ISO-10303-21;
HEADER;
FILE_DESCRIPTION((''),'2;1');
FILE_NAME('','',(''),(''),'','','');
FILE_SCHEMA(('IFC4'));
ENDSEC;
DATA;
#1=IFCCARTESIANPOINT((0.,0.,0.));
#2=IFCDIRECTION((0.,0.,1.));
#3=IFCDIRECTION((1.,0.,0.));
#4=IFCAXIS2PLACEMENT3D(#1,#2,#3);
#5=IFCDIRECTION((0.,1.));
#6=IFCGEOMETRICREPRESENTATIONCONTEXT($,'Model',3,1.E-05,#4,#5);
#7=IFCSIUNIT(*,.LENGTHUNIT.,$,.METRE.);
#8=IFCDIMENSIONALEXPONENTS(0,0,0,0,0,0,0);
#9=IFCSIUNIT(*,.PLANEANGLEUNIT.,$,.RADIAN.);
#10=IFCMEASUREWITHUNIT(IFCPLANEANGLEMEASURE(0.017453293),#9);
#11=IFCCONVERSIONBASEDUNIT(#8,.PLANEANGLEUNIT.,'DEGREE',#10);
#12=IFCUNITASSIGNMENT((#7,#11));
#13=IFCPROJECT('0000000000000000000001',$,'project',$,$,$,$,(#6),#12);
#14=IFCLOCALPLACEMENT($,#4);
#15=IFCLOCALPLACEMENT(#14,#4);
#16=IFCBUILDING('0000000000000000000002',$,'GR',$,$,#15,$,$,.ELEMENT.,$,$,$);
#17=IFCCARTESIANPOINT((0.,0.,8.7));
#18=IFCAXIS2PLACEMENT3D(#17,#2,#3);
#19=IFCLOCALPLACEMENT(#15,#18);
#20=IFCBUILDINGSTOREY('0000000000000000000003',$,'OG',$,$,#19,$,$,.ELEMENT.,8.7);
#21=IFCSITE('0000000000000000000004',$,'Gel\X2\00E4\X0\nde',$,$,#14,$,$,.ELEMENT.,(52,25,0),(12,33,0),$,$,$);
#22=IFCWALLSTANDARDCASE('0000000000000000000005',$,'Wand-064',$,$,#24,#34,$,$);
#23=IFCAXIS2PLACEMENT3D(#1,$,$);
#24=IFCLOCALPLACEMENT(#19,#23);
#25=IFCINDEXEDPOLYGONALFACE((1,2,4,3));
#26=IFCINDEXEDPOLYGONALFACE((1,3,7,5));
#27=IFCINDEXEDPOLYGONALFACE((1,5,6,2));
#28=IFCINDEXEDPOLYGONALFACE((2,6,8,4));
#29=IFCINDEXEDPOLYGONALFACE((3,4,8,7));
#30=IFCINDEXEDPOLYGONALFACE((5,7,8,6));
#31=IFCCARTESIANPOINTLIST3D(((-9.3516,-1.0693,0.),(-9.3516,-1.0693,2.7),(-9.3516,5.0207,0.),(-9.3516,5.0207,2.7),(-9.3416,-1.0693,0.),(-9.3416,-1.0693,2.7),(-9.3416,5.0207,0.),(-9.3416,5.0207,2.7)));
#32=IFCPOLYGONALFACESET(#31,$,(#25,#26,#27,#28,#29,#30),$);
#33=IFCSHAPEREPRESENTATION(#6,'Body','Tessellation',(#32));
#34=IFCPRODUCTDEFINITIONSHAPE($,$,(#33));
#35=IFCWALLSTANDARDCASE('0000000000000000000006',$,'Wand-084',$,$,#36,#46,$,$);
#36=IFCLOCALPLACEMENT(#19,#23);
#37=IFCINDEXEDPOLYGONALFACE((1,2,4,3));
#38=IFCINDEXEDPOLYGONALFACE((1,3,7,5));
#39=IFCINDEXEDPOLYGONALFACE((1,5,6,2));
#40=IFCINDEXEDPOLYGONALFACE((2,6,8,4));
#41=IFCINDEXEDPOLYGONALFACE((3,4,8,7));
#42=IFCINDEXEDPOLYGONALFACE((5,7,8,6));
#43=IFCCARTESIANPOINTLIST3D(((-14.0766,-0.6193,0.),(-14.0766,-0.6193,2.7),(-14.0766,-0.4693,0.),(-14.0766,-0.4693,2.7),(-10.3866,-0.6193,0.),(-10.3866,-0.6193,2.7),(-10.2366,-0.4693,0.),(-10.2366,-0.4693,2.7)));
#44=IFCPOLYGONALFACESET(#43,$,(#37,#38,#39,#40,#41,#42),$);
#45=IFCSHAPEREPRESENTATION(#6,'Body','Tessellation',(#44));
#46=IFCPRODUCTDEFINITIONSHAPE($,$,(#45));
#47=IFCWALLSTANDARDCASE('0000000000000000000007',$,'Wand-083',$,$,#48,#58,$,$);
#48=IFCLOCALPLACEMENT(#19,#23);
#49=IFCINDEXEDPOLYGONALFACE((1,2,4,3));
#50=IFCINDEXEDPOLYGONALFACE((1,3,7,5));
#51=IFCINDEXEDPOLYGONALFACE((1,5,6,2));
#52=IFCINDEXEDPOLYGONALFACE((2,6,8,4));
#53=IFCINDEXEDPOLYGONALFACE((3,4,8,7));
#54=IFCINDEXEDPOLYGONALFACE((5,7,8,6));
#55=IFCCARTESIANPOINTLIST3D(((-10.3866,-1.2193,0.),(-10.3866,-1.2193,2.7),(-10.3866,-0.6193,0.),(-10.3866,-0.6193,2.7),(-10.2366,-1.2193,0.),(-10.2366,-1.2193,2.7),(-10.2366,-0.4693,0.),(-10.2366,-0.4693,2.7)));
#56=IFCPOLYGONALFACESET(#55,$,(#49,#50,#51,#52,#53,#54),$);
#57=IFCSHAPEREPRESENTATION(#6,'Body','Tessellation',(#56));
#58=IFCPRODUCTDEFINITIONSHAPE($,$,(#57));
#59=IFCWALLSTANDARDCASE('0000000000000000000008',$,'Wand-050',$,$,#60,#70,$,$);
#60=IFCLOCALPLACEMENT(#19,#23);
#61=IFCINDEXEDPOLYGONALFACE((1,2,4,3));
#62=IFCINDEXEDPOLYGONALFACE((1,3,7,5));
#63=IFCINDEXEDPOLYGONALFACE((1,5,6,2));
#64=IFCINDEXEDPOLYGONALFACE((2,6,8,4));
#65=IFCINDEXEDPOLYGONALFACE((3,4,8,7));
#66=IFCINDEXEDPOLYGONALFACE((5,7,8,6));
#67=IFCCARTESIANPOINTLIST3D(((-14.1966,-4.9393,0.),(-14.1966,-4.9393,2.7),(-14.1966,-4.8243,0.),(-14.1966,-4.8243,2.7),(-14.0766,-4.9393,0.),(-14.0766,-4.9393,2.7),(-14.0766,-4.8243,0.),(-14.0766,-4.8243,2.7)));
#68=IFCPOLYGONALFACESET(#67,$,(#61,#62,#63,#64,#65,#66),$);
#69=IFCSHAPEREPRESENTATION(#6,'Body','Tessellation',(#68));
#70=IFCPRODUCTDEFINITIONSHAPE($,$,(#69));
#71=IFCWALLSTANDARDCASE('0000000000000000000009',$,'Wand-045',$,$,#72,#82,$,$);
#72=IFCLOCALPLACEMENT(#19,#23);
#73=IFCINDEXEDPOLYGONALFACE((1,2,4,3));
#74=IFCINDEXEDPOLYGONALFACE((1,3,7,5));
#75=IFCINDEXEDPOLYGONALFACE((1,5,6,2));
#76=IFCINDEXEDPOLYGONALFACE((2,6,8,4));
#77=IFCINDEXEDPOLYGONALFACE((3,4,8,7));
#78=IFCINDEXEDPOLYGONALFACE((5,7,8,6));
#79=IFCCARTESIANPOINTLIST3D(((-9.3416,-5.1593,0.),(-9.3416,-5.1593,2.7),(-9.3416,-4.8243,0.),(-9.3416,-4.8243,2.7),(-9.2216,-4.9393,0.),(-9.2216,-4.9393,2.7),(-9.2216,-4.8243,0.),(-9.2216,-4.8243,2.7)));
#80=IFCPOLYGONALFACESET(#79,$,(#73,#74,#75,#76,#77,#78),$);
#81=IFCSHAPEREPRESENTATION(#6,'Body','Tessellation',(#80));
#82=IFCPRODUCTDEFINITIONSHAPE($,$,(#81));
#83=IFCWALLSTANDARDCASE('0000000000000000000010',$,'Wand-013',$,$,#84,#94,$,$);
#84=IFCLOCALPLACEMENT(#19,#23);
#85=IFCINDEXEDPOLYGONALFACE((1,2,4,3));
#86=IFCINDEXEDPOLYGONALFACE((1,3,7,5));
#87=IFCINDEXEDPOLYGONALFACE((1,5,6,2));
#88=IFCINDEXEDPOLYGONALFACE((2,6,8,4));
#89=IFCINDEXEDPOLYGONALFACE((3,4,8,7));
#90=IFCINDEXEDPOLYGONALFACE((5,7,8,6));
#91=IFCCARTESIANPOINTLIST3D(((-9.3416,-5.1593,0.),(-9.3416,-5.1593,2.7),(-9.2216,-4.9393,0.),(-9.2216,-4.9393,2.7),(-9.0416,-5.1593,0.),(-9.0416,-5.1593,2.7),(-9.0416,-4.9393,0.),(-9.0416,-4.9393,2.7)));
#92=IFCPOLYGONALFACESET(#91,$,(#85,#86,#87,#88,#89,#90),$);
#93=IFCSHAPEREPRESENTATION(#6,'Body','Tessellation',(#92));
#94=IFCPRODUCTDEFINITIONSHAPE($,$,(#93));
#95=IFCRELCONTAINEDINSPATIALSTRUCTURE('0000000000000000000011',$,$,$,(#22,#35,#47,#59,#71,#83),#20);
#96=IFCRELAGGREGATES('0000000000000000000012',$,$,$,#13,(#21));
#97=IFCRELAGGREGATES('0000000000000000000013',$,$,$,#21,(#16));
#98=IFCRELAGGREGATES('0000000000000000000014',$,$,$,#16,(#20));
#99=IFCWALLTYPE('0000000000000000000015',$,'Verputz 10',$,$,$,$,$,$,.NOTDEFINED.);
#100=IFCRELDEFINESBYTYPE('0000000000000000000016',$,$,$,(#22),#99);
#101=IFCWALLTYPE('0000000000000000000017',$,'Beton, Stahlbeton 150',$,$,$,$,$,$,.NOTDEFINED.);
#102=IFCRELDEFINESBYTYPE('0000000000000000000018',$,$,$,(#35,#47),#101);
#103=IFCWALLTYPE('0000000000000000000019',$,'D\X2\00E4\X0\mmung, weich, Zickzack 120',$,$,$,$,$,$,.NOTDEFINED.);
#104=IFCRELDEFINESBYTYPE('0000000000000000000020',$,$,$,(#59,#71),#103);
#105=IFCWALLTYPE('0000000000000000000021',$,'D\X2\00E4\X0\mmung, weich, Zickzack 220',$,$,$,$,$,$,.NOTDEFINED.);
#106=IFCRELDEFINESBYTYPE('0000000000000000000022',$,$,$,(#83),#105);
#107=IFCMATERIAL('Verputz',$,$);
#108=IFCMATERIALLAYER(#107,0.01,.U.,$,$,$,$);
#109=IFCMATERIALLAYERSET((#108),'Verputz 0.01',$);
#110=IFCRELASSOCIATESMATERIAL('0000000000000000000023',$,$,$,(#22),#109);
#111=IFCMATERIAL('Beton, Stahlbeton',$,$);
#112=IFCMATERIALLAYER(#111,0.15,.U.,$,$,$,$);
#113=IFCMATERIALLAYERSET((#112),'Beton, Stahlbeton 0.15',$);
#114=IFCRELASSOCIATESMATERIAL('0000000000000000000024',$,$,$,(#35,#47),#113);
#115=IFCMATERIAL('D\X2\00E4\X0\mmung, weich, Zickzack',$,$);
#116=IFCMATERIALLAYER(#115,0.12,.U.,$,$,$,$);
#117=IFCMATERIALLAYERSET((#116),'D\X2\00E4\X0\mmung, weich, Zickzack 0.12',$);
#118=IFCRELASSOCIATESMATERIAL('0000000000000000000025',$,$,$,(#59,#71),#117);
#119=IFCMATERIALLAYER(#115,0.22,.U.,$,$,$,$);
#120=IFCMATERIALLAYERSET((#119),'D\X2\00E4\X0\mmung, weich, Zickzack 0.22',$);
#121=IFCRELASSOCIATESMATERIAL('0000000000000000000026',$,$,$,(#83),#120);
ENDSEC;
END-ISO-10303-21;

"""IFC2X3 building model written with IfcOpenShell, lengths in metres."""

from ifc_helpers import new_model, entity, si_unit, converted_unit, direction, frame, origin_with_axes, place, context, project, spatial, polyline, outline, extrude, material, layer, layer_set, layer_usage, type_object, element, save


model = new_model("IFC2X3")

# Units and contexts
model_context = context("Model", 3, precision=1e-05, world=origin_with_axes(), true_north=direction((0.0, 1.0)))
ifc_project = project(units=[si_unit("LENGTHUNIT", "METRE"), converted_unit("PLANEANGLEUNIT", "DEGREE", entity("IfcPlaneAngleMeasure", 0.017453293), si_unit("PLANEANGLEUNIT", "RADIAN"), dimensions=[0, 0, 0, 0, 0, 0, 0])], contexts=[model_context])

# Site, building, storey
site_placement = place(None, origin_with_axes())
site = spatial("IfcSite", under=ifc_project, at=site_placement, Name="Gelände", CompositionType="ELEMENT", RefLatitude=(52, 25, 0), RefLongitude=(12, 33, 0))
building_placement = place(site_placement, origin_with_axes())
building = spatial("IfcBuilding", under=site, at=building_placement, Name="GR", CompositionType="ELEMENT")
storey_placement = place(building_placement, frame((0.0, 0.0, 8.7), z_axis=(0.0, 0.0, 1.0), x_axis=(1.0, 0.0, 0.0)))
storey = spatial("IfcBuildingStorey", under=building, at=storey_placement, Name="OG", CompositionType="ELEMENT", Elevation=8.7)

# Shared definitions
ifc_material_1 = material(Name="Beton, Stahlbeton")

# Wall
ifc_material_2 = material(Name="Verputz")
ifc_layer_1 = layer(ifc_material_2, 0.01, ventilated="UNKNOWN")
ifc_layer_set_1 = layer_set([ifc_layer_1], Name="Verputz 0.01")
wall_type_1 = type_object("IfcWallType", Name="Verputz 10", PredefinedType="NOTDEFINED")
ifc_layer_usage_1 = layer_usage(ifc_layer_set_1, "AXIS2", "POSITIVE", 0.0)
wall_1_placement = place(storey_placement, frame((-9.3416, -1.0693, 0.0), z_axis=(0.0, 0.0, 1.0), x_axis=(0.0, 1.0, 0.0)))
element("IfcWallStandardCase", 1, at=wall_1_placement, inside=storey, type_object=wall_type_1, material=ifc_layer_usage_1, Name="Wand-064", context=model_context, shape_type="SweptSolid", body=[
    extrude(outline(polyline([(0.0, 0.0), (6.09, 0.0), (6.09, 0.01), (0.0, 0.01), (0.0, 0.0)])), origin_with_axes(), (0.0, 0.0, 1.0), 2.7),
])

# Shared definitions
ifc_layer_2 = layer(ifc_material_1, 0.15, ventilated="UNKNOWN")
ifc_layer_set_2 = layer_set([ifc_layer_2], Name="Beton, Stahlbeton 0.15")
wall_type_2 = type_object("IfcWallType", Name="Beton, Stahlbeton 150", PredefinedType="NOTDEFINED")

# Wall
ifc_layer_usage_2 = layer_usage(ifc_layer_set_2, "AXIS2", "NEGATIVE", 0.0)
wall_2_placement = place(storey_placement, frame((-10.3866, -0.6193, 0.0), z_axis=(0.0, 0.0, 1.0), x_axis=(-1.0, 0.0, 0.0)))
element("IfcWallStandardCase", 2, at=wall_2_placement, inside=storey, type_object=wall_type_2, material=ifc_layer_usage_2, Name="Wand-084", context=model_context, shape_type="SweptSolid", body=[
    extrude(outline(polyline([(-0.15, -0.15), (3.69, -0.15), (3.69, 0.0), (0.0, 0.0), (-0.15, -0.15)])), origin_with_axes(), (0.0, 0.0, 1.0), 2.7),
])

# Walls
ifc_layer_usage_3 = layer_usage(ifc_layer_set_2, "AXIS2", "NEGATIVE", 0.0)
wall_3_placement = place(storey_placement, frame((-10.3866, -1.2193, 0.0), z_axis=(0.0, 0.0, 1.0), x_axis=(0.0, 1.0, 0.0)))
element("IfcWallStandardCase", 3, at=wall_3_placement, inside=storey, type_object=wall_type_2, material=ifc_layer_usage_3, Name="Wand-083", context=model_context, shape_type="SweptSolid", body=[
    extrude(outline(polyline([(0.0, -0.15), (0.75, -0.15), (0.6, 0.0), (0.0, 0.0), (0.0, -0.15)])), origin_with_axes(), (0.0, 0.0, 1.0), 2.7),
])
ifc_material_3 = material(Name="Dämmung, weich, Zickzack")
ifc_layer_3 = layer(ifc_material_3, 0.12, ventilated="UNKNOWN")
ifc_layer_set_3 = layer_set([ifc_layer_3], Name="Dämmung, weich, Zickzack 0.12")
ifc_layer_usage_4 = layer_usage(ifc_layer_set_3, "AXIS2", "POSITIVE", 0.0)
wall_type_3 = type_object("IfcWallType", Name="Dämmung, weich, Zickzack 120", PredefinedType="NOTDEFINED")
wall_4_placement = place(storey_placement, frame((-14.0766, -4.9393, 0.0), z_axis=(0.0, 0.0, 1.0), x_axis=(0.0, 1.0, 0.0)))
element("IfcWallStandardCase", 4, at=wall_4_placement, inside=storey, type_object=wall_type_3, material=ifc_layer_usage_4, Name="Wand-050", context=model_context, shape_type="SweptSolid", body=[
    extrude(outline(polyline([(0.0, 0.0), (0.115, 0.0), (0.115, 0.12), (0.0, 0.12), (0.0, 0.0)])), origin_with_axes(), (0.0, 0.0, 1.0), 2.7),
])
ifc_layer_usage_5 = layer_usage(ifc_layer_set_3, "AXIS2", "POSITIVE", 0.0)
wall_5_placement = place(storey_placement, frame((-9.3416, -4.8243, 0.0), z_axis=(0.0, 0.0, 1.0), x_axis=(0.0, -1.0, 0.0)))
element("IfcWallStandardCase", 5, at=wall_5_placement, inside=storey, type_object=wall_type_3, material=ifc_layer_usage_5, Name="Wand-045", context=model_context, shape_type="SweptSolid", body=[
    extrude(outline(polyline([(0.0, 0.0), (0.335, 0.0), (0.115, 0.12), (0.0, 0.12), (0.0, 0.0)])), origin_with_axes(), (0.0, 0.0, 1.0), 2.7),
])
ifc_layer_4 = layer(ifc_material_3, 0.22, ventilated="UNKNOWN")
ifc_layer_set_4 = layer_set([ifc_layer_4], Name="Dämmung, weich, Zickzack 0.22")
ifc_layer_usage_6 = layer_usage(ifc_layer_set_4, "AXIS2", "NEGATIVE", 0.0)
wall_type_4 = type_object("IfcWallType", Name="Dämmung, weich, Zickzack 220", PredefinedType="NOTDEFINED")
wall_6_placement = place(storey_placement, frame((-9.0416, -5.1593, 0.0), z_axis=(0.0, 0.0, 1.0), x_axis=(-1.0, 0.0, 0.0)))
element("IfcWallStandardCase", 6, at=wall_6_placement, inside=storey, type_object=wall_type_4, material=ifc_layer_usage_6, Name="Wand-013", context=model_context, shape_type="SweptSolid", body=[
    extrude(outline(polyline([(0.0, -0.22), (0.18, -0.22), (0.3, 0.0), (0.0, 0.0), (0.0, -0.22)])), origin_with_axes(), (0.0, 0.0, 1.0), 2.7),
])

save(model, "model.ifc")
